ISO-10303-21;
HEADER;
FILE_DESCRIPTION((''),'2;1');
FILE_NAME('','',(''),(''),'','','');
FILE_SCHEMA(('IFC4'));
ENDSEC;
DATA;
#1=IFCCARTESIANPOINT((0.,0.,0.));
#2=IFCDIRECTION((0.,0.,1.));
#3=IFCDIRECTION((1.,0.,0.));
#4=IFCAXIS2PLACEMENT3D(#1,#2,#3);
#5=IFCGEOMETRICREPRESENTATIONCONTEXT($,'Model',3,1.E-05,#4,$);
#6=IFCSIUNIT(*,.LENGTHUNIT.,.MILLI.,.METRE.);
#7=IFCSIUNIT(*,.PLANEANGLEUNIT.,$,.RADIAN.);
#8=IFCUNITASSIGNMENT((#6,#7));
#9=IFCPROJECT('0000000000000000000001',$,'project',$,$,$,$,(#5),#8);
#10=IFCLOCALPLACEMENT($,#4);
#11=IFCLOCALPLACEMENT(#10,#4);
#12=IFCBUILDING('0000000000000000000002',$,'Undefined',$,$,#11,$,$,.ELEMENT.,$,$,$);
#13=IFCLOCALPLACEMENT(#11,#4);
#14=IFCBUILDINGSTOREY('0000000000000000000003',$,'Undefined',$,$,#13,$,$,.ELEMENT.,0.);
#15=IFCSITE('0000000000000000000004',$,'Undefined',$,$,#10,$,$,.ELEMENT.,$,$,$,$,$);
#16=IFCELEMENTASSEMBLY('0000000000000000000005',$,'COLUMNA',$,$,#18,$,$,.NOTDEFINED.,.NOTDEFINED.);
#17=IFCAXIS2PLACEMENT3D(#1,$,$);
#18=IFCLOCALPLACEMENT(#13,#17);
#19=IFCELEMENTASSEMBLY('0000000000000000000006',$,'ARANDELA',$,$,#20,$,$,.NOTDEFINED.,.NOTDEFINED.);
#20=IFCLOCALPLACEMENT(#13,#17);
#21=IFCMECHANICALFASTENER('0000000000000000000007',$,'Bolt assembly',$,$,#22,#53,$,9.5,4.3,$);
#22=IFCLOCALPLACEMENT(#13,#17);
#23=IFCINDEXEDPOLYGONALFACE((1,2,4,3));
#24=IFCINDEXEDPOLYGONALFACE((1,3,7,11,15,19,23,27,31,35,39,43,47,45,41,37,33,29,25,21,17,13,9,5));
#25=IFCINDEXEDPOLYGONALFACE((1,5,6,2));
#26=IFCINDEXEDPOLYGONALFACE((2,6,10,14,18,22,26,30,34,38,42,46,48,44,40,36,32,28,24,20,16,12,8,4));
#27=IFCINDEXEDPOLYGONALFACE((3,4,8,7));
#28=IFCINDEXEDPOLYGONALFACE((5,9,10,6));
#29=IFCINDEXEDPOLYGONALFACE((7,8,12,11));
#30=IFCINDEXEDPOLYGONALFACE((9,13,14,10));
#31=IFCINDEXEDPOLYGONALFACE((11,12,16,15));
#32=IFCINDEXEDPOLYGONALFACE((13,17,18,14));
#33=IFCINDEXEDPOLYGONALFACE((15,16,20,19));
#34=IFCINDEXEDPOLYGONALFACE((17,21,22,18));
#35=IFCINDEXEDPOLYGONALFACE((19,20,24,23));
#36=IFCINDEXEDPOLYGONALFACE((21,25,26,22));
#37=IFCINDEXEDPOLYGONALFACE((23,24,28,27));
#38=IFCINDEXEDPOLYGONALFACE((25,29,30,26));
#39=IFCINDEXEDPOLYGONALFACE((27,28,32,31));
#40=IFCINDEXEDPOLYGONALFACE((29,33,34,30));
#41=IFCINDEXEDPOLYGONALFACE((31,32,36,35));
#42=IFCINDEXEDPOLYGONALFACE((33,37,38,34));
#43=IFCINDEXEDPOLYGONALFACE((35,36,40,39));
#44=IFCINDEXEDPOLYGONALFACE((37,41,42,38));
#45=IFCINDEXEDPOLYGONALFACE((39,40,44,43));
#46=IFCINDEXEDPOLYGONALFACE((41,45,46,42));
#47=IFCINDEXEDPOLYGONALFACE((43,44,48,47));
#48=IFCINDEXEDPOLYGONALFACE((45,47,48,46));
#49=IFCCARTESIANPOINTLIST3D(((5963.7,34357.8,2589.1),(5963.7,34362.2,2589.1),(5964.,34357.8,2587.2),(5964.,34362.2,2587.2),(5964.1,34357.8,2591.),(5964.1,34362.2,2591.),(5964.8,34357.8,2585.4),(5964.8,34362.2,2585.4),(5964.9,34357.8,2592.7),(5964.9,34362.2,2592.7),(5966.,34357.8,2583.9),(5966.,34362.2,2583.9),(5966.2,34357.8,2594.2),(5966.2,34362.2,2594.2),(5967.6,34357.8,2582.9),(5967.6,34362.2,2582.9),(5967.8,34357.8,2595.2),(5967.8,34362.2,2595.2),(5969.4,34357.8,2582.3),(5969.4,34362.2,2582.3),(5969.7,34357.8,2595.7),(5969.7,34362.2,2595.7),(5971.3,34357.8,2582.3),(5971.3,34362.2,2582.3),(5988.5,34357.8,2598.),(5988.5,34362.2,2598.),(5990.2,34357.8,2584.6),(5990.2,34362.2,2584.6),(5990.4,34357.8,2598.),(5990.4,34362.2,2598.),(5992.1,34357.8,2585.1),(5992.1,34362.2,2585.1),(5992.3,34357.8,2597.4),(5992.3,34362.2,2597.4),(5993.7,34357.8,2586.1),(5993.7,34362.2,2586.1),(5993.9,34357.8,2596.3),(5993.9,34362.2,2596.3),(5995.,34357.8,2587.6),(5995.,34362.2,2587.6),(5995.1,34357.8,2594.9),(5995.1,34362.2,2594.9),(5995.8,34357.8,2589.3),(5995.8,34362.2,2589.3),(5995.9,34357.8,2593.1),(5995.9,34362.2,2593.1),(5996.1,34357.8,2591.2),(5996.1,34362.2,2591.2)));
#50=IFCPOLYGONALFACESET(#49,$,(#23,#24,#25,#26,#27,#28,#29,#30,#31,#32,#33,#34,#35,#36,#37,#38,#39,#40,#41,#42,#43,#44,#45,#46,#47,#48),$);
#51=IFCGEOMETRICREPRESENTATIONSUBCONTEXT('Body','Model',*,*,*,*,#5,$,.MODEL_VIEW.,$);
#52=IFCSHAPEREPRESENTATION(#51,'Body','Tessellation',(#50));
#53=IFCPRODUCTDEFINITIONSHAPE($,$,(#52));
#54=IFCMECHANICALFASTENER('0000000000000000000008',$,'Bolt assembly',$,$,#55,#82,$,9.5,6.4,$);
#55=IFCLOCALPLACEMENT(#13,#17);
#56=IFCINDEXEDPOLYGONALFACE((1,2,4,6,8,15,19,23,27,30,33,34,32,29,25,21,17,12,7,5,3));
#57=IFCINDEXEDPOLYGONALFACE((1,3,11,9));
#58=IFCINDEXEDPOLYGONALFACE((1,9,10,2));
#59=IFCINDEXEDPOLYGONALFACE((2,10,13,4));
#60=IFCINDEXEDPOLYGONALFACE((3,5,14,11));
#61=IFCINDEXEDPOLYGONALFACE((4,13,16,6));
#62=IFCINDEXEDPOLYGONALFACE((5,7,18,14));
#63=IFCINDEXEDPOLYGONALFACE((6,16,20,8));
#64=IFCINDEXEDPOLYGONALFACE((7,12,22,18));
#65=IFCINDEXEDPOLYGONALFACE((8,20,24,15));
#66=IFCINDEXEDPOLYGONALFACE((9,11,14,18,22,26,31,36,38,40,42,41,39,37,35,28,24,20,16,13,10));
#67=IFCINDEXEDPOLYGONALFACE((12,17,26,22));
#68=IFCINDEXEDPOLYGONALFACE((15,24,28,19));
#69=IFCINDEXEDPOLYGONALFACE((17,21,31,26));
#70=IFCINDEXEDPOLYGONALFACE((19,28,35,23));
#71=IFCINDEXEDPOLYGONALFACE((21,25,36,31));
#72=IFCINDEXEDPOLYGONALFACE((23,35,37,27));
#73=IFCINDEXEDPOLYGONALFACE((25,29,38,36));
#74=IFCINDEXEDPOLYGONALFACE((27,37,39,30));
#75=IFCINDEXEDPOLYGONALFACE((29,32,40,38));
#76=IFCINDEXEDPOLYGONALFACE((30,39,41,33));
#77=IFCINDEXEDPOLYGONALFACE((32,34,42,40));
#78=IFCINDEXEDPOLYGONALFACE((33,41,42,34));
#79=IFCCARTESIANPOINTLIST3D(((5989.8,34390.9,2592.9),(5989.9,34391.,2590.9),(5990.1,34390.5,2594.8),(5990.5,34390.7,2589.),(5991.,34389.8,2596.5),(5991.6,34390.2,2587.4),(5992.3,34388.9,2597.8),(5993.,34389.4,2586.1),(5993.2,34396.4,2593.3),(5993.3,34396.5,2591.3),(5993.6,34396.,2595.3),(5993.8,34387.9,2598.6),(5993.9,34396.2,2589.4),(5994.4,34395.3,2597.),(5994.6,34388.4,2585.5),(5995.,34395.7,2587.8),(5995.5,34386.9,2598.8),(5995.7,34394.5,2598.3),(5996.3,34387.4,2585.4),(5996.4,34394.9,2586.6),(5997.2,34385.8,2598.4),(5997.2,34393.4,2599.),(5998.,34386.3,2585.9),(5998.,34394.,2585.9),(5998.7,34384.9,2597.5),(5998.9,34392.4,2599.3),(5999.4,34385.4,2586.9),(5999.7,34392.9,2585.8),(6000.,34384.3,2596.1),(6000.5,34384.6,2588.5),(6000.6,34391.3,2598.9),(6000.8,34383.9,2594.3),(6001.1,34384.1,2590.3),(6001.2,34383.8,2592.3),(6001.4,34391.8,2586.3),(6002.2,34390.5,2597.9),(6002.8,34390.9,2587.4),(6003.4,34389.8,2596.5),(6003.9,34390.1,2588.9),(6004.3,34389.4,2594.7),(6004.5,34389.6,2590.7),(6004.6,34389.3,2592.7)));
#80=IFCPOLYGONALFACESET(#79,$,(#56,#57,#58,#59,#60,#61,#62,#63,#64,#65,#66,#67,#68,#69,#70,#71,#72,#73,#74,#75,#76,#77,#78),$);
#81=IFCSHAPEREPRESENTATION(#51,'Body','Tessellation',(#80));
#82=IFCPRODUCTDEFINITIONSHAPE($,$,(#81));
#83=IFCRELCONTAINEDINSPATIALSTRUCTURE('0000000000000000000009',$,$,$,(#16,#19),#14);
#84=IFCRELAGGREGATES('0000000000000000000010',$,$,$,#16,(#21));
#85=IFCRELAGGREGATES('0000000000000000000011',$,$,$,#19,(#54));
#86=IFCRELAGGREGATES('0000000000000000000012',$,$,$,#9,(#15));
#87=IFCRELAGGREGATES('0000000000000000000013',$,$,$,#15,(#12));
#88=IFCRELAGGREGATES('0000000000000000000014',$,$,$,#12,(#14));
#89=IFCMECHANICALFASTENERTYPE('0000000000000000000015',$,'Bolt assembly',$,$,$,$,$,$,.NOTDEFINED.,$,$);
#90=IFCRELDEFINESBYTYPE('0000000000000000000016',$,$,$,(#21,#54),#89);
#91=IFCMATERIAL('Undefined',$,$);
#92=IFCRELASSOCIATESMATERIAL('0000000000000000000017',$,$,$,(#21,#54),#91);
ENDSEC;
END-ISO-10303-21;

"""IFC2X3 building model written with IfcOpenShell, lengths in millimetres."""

from ifc_helpers import new_model, si_unit, frame, frame_2d, origin_with_axes, origin_2d_with_axis, place, context, subcontext, project, spatial, polyline, circle_curve, parameter, trimmed, segment, composite_curve, circle, outline, extrude, source, transform, mapped, material, type_object, element, aggregate, save


model = new_model("IFC2X3")

# Units and contexts
model_context = context("Model", 3, precision=1e-05, world=origin_with_axes())
body_context = subcontext(model_context, "Body", "Model", "MODEL_VIEW")
ifc_project = project(units=[si_unit("LENGTHUNIT", "METRE", prefix="MILLI"), si_unit("PLANEANGLEUNIT", "RADIAN")], contexts=[model_context])

# Site, building, storey
site_placement = place(None, origin_with_axes())
site = spatial("IfcSite", under=ifc_project, at=site_placement, Name="Undefined", CompositionType="ELEMENT")
building_placement = place(site_placement, origin_with_axes())
building = spatial("IfcBuilding", under=site, at=building_placement, Name="Undefined", CompositionType="ELEMENT")
storey_placement = place(building_placement, origin_with_axes())
storey = spatial("IfcBuildingStorey", under=building, at=storey_placement, Name="Undefined", CompositionType="ELEMENT", Elevation=0.0)

# Element assembly
assembly_1_placement = place(storey_placement, origin_with_axes())
assembly_1 = element("IfcElementAssembly", 1, at=assembly_1_placement, inside=storey, Name="COLUMNA", AssemblyPlace="NOTDEFINED", PredefinedType="NOTDEFINED")

# Element assembly
assembly_2_placement = place(storey_placement, origin_with_axes())
assembly_2 = element("IfcElementAssembly", 2, at=assembly_2_placement, inside=storey, Name="ARANDELA", AssemblyPlace="NOTDEFINED", PredefinedType="NOTDEFINED")

# Mechanical fastener
ifc_material_1 = material(Name="Undefined")
mechanical_fastener_type = type_object("IfcMechanicalFastenerType", Name="Bolt assembly")
shared_shape_1 = source(origin_with_axes(), body_context, "Body", "SweptSolid", [
    extrude(outline(composite_curve([segment(polyline([(-9.5, 6.8), (9.5, 6.8)]), True, "CONTINUOUS"), segment(trimmed(circle_curve(frame_2d((9.5, 0.0), x_axis=(0.0, 1.0)), 6.8), [parameter(0.0)], [parameter(3.141593)], False, "PARAMETER"), True, "CONTINUOUS"), segment(polyline([(9.5, -6.8), (-9.5, -6.8)]), True, "CONTINUOUS"), segment(trimmed(circle_curve(frame_2d((-9.5, 0.0), x_axis=(0.0, -1.0)), 6.8), [parameter(0.0)], [parameter(3.141593)], False, "PARAMETER"), True, "DISCONTINUOUS")], self_intersect=False)), frame((0.0, 0.0, 0.0), z_axis=(0.0, 1.0, 0.0), x_axis=(1.0, 0.0, 0.0)), (0.0, 0.0, 1.0), 4.4),
])
mechanical_fastener_1_placement = place(assembly_1_placement, frame((5979.9, 34362.2, 2590.1), z_axis=(-0.124075, 0.0, 0.992273), x_axis=(-0.992273, 0.0, -0.124075)))
mechanical_fastener_1 = element("IfcMechanicalFastener", 3, at=mechanical_fastener_1_placement, type_object=mechanical_fastener_type, material=ifc_material_1, Name="Bolt assembly", NominalDiameter=9.5, NominalLength=4.3, context=body_context, shape_type="MappedRepresentation", body=[
    mapped(shared_shape_1, transform((0.0, 0.0, 0.0))),
])
aggregate(assembly_1, [mechanical_fastener_1])

# Mechanical fastener
shared_shape_2 = source(origin_with_axes(), body_context, "Body", "SweptSolid", [
    extrude(circle(Radius=6.8, at=origin_2d_with_axis()), frame((0.0, -6.4, 0.0), z_axis=(0.0, 1.0, 0.0), x_axis=(1.0, 0.0, 0.0)), (0.0, 0.0, 1.0), 6.5),
])
mechanical_fastener_2_placement = place(assembly_2_placement, frame((5995.5, 34387.5, 2592.1), z_axis=(-0.841338, 0.530172, -0.105202), x_axis=(0.124075, 0.0, -0.992273)))
mechanical_fastener_2 = element("IfcMechanicalFastener", 4, at=mechanical_fastener_2_placement, type_object=mechanical_fastener_type, material=ifc_material_1, Name="Bolt assembly", NominalDiameter=9.5, NominalLength=6.4, context=body_context, shape_type="MappedRepresentation", body=[
    mapped(shared_shape_2, transform((0.0, 0.0, 0.0))),
])
aggregate(assembly_2, [mechanical_fastener_2])

save(model, "model.ifc")
